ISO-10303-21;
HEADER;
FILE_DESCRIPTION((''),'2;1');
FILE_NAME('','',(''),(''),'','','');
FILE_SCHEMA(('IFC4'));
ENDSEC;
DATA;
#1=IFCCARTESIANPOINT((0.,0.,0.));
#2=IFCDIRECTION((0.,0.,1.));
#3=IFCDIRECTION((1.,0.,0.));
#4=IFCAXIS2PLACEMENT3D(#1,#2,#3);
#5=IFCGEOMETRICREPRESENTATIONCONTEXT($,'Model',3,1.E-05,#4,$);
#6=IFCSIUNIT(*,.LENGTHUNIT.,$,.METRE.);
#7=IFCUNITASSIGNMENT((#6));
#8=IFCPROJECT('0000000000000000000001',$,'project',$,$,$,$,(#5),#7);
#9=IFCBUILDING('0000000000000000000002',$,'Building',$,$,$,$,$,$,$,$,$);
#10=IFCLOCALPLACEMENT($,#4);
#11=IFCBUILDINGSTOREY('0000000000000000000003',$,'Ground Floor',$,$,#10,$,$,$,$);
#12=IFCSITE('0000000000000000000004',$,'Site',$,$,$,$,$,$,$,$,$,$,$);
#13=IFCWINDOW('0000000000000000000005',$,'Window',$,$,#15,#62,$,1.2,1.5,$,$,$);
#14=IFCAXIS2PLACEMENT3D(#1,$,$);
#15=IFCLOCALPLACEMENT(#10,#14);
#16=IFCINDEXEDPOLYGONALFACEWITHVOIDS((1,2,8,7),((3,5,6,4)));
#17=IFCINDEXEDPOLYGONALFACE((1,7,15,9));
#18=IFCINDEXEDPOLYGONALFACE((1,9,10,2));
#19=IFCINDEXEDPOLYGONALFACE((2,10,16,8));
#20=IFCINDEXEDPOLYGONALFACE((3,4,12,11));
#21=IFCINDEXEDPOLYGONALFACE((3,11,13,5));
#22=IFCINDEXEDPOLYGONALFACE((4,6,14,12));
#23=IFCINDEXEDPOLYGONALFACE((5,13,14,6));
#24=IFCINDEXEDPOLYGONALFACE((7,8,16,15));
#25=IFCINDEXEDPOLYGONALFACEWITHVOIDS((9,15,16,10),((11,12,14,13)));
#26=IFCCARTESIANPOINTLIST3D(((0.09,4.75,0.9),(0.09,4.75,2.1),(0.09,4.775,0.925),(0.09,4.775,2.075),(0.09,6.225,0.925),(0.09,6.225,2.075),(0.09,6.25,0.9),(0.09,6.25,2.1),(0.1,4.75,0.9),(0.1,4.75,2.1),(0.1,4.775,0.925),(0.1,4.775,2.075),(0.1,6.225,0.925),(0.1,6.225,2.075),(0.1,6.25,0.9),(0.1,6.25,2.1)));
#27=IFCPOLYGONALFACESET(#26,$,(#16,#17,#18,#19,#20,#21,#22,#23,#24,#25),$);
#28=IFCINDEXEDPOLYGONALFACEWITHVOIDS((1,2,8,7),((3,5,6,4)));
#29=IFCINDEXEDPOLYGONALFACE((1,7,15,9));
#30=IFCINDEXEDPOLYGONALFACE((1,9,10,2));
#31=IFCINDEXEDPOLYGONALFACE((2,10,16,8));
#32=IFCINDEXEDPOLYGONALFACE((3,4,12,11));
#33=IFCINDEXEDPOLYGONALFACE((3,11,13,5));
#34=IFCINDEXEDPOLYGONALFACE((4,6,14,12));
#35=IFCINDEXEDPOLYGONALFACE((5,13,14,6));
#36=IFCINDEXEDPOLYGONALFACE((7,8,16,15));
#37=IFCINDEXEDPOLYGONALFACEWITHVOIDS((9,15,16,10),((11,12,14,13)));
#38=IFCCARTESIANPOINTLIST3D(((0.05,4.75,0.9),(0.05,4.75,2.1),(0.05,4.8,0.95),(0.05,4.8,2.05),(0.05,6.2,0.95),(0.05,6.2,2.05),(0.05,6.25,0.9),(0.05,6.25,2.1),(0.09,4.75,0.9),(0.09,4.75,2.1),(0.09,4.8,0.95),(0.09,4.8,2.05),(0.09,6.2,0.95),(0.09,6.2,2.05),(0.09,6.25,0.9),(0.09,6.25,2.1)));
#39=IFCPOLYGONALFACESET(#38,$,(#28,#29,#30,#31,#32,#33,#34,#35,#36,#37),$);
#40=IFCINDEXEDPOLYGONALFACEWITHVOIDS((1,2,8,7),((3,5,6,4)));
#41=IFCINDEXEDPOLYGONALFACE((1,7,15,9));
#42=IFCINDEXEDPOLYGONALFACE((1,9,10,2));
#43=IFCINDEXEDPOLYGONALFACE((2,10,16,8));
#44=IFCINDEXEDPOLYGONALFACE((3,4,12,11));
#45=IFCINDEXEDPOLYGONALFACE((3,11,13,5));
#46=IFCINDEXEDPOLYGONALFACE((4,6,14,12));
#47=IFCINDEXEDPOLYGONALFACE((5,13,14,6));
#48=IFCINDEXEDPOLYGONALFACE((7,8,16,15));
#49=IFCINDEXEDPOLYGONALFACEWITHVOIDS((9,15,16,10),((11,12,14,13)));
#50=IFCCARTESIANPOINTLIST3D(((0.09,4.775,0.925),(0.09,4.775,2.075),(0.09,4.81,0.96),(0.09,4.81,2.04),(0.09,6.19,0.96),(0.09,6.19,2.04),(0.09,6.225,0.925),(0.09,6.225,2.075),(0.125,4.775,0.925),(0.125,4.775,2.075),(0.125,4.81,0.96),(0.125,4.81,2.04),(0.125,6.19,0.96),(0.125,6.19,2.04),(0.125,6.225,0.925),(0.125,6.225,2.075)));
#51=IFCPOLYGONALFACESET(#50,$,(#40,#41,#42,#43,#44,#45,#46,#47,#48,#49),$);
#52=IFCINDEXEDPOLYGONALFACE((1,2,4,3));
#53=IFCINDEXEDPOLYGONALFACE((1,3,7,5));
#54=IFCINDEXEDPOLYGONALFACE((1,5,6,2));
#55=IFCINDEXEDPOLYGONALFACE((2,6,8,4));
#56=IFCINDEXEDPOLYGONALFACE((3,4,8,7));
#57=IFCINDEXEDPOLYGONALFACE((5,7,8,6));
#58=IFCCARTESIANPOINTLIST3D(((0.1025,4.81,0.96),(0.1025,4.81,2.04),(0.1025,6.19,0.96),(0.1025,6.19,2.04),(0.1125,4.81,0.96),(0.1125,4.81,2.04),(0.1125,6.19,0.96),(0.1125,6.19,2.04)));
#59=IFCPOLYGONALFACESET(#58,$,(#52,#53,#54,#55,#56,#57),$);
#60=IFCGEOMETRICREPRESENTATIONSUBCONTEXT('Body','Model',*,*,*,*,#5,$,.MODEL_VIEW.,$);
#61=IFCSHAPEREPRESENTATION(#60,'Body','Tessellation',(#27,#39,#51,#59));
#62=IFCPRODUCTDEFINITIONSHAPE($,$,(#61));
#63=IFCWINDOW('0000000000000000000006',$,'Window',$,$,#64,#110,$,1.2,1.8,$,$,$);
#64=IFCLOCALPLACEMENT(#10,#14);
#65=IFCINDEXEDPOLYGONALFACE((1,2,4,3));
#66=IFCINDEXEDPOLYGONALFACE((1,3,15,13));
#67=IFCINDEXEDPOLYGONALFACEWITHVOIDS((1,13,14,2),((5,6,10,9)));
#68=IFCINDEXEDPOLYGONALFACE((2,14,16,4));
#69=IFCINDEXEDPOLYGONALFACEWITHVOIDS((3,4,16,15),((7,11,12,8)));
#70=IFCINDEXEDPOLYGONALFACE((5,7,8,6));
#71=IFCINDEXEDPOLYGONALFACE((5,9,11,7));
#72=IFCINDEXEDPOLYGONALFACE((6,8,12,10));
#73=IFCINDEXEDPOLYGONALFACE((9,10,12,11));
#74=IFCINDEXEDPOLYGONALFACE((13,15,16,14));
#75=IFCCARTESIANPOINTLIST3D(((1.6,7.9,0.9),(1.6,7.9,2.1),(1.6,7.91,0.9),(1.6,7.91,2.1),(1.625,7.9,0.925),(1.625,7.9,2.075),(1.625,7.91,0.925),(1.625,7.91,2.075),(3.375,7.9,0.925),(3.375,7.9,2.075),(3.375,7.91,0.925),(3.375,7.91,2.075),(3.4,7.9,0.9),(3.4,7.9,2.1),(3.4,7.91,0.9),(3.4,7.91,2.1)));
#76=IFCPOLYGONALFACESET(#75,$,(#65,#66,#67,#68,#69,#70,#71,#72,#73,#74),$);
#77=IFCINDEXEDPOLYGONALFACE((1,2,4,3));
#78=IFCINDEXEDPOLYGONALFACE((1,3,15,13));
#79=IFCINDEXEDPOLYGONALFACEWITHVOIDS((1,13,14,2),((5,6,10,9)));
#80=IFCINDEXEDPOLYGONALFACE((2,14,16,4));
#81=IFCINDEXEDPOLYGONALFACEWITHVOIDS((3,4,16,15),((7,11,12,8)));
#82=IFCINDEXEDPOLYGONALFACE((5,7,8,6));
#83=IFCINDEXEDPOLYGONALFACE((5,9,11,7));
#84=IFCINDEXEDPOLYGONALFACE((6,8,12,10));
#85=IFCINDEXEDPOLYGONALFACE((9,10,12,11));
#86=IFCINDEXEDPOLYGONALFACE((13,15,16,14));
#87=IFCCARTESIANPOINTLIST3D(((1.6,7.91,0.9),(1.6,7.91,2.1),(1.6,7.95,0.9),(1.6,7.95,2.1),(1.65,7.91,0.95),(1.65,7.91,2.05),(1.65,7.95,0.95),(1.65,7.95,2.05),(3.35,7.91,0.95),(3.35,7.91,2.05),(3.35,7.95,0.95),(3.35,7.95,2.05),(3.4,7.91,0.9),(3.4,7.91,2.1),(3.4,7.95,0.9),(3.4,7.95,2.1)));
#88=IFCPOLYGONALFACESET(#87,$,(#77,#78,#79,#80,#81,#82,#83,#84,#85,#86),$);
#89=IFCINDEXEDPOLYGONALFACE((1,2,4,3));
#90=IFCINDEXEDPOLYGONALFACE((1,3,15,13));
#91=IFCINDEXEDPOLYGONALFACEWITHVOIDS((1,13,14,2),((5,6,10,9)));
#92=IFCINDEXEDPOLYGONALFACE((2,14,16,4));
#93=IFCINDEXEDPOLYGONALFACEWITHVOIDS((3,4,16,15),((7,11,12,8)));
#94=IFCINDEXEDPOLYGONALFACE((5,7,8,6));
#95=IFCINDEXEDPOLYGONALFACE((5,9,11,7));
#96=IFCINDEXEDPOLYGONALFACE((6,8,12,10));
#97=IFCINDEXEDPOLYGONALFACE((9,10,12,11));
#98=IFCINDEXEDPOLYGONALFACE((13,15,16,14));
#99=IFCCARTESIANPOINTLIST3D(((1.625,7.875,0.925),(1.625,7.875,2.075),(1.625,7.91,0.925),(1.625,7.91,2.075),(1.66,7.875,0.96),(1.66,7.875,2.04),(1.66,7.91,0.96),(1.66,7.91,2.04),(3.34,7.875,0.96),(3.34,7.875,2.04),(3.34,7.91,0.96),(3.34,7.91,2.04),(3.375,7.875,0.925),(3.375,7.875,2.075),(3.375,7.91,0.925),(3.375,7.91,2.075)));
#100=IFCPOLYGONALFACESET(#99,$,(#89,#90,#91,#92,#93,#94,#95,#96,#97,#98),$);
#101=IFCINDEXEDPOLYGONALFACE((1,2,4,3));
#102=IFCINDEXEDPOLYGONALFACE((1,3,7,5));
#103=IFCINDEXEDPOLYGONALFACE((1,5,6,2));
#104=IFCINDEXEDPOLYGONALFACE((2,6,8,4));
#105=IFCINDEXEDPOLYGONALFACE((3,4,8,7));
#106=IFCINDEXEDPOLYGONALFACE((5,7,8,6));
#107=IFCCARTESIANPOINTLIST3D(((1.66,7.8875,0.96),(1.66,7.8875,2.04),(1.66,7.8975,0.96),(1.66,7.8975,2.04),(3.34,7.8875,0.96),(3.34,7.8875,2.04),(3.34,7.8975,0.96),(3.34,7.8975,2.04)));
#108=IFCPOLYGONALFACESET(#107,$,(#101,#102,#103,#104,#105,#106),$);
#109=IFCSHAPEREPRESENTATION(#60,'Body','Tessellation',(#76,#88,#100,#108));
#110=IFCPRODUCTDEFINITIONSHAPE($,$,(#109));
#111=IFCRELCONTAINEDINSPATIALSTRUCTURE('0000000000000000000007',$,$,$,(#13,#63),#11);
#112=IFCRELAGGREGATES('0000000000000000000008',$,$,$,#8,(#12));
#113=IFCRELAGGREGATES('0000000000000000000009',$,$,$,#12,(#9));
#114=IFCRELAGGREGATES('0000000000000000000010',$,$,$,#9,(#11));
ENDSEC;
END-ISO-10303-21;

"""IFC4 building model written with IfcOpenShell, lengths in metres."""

from ifc_helpers import new_model, si_unit, frame, origin_with_axes, place, context, subcontext, project, spatial, line, indexed_curve, outline, extrude, element, save


model = new_model("IFC4")

# Units and contexts
model_context = context("Model", 3, precision=1e-05, world=origin_with_axes())
body_context = subcontext(model_context, "Body", "Model", "MODEL_VIEW")
ifc_project = project(units=[si_unit("LENGTHUNIT", "METRE")], contexts=[model_context])

# Site, building, storey
site = spatial("IfcSite", under=ifc_project, Name="Site")
building = spatial("IfcBuilding", under=site, Name="Building")
storey_placement = place(None, origin_with_axes())
storey = spatial("IfcBuildingStorey", under=building, at=storey_placement, Name="Ground Floor")

# Windows
for number, where, z_axis, x_axis, name in (
    (1, (0.0, 6.25, 0.9), (0.0, 0.0, 1.0), (0.0, -1.0, 0.0), "Window"),
):
    element("IfcWindow", number, at=place(storey_placement, frame(where, z_axis=z_axis, x_axis=x_axis)), inside=storey, Name=name, OverallHeight=1.2, OverallWidth=1.5, context=body_context, shape_type="SweptSolid", body=[
        extrude(outline(indexed_curve([(0.0, 0.0), (1.5, 0.0), (1.5, 1.2), (0.0, 1.2)], segments=[line(1, 2, 3, 4, 1)]), holes=[indexed_curve([(0.025, 0.025), (1.475, 0.025), (1.475, 1.175), (0.025, 1.175)], segments=[line(1, 2, 3, 4, 1)])]), frame((0.0, 0.09, 0.0), z_axis=(0.0, -1.0, 0.0), x_axis=(1.0, 0.0, 0.0)), (0.0, 0.0, -1.0), 0.01),
        extrude(outline(indexed_curve([(0.0, 0.0), (1.5, 0.0), (1.5, 1.2), (0.0, 1.2)], segments=[line(1, 2, 3, 4, 1)]), holes=[indexed_curve([(0.05, 0.05), (1.45, 0.05), (1.45, 1.15), (0.05, 1.15)], segments=[line(1, 2, 3, 4, 1)])]), frame((0.0, 0.05, 0.0), z_axis=(0.0, -1.0, 0.0), x_axis=(1.0, 0.0, 0.0)), (0.0, 0.0, -1.0), 0.04),
        extrude(outline(indexed_curve([(0.0, 0.0), (1.45, 0.0), (1.45, 1.15), (0.0, 1.15)], segments=[line(1, 2, 3, 4, 1)]), holes=[indexed_curve([(0.035, 0.035), (1.415, 0.035), (1.415, 1.115), (0.035, 1.115)], segments=[line(1, 2, 3, 4, 1)])]), frame((0.025, 0.09, 0.025), z_axis=(0.0, -1.0, 0.0), x_axis=(1.0, 0.0, 0.0)), (0.0, 0.0, -1.0), 0.035),
        extrude(outline(indexed_curve([(0.035, 0.035), (1.415, 0.035), (1.415, 1.115), (0.035, 1.115)], segments=[line(1, 2, 3, 4, 1)])), frame((0.025, 0.1025, 0.025), z_axis=(0.0, -1.0, 0.0), x_axis=(1.0, 0.0, 0.0)), (0.0, 0.0, -1.0), 0.01),
    ])
window_1_placement = place(storey_placement, frame((3.4, 8.0, 0.9), z_axis=(0.0, 0.0, 1.0), x_axis=(-1.0, 0.0, 0.0)))
element("IfcWindow", 2, at=window_1_placement, inside=storey, Name="Window", OverallHeight=1.2, OverallWidth=1.8, context=body_context, shape_type="SweptSolid", body=[
    extrude(outline(indexed_curve([(0.0, 0.0), (1.8, 0.0), (1.8, 1.2), (0.0, 1.2)], segments=[line(1, 2, 3, 4, 1)]), holes=[indexed_curve([(0.025, 0.025), (1.775, 0.025), (1.775, 1.175), (0.025, 1.175)], segments=[line(1, 2, 3, 4, 1)])]), frame((0.0, 0.09, 0.0), z_axis=(0.0, -1.0, 0.0), x_axis=(1.0, 0.0, 0.0)), (0.0, 0.0, -1.0), 0.01),
    extrude(outline(indexed_curve([(0.0, 0.0), (1.8, 0.0), (1.8, 1.2), (0.0, 1.2)], segments=[line(1, 2, 3, 4, 1)]), holes=[indexed_curve([(0.05, 0.05), (1.75, 0.05), (1.75, 1.15), (0.05, 1.15)], segments=[line(1, 2, 3, 4, 1)])]), frame((0.0, 0.05, 0.0), z_axis=(0.0, -1.0, 0.0), x_axis=(1.0, 0.0, 0.0)), (0.0, 0.0, -1.0), 0.04),
    extrude(outline(indexed_curve([(0.0, 0.0), (1.75, 0.0), (1.75, 1.15), (0.0, 1.15)], segments=[line(1, 2, 3, 4, 1)]), holes=[indexed_curve([(0.035, 0.035), (1.715, 0.035), (1.715, 1.115), (0.035, 1.115)], segments=[line(1, 2, 3, 4, 1)])]), frame((0.025, 0.09, 0.025), z_axis=(0.0, -1.0, 0.0), x_axis=(1.0, 0.0, 0.0)), (0.0, 0.0, -1.0), 0.035),
    extrude(outline(indexed_curve([(0.035, 0.035), (1.715, 0.035), (1.715, 1.115), (0.035, 1.115)], segments=[line(1, 2, 3, 4, 1)])), frame((0.025, 0.1025, 0.025), z_axis=(0.0, -1.0, 0.0), x_axis=(1.0, 0.0, 0.0)), (0.0, 0.0, -1.0), 0.01),
])

save(model, "model.ifc")
